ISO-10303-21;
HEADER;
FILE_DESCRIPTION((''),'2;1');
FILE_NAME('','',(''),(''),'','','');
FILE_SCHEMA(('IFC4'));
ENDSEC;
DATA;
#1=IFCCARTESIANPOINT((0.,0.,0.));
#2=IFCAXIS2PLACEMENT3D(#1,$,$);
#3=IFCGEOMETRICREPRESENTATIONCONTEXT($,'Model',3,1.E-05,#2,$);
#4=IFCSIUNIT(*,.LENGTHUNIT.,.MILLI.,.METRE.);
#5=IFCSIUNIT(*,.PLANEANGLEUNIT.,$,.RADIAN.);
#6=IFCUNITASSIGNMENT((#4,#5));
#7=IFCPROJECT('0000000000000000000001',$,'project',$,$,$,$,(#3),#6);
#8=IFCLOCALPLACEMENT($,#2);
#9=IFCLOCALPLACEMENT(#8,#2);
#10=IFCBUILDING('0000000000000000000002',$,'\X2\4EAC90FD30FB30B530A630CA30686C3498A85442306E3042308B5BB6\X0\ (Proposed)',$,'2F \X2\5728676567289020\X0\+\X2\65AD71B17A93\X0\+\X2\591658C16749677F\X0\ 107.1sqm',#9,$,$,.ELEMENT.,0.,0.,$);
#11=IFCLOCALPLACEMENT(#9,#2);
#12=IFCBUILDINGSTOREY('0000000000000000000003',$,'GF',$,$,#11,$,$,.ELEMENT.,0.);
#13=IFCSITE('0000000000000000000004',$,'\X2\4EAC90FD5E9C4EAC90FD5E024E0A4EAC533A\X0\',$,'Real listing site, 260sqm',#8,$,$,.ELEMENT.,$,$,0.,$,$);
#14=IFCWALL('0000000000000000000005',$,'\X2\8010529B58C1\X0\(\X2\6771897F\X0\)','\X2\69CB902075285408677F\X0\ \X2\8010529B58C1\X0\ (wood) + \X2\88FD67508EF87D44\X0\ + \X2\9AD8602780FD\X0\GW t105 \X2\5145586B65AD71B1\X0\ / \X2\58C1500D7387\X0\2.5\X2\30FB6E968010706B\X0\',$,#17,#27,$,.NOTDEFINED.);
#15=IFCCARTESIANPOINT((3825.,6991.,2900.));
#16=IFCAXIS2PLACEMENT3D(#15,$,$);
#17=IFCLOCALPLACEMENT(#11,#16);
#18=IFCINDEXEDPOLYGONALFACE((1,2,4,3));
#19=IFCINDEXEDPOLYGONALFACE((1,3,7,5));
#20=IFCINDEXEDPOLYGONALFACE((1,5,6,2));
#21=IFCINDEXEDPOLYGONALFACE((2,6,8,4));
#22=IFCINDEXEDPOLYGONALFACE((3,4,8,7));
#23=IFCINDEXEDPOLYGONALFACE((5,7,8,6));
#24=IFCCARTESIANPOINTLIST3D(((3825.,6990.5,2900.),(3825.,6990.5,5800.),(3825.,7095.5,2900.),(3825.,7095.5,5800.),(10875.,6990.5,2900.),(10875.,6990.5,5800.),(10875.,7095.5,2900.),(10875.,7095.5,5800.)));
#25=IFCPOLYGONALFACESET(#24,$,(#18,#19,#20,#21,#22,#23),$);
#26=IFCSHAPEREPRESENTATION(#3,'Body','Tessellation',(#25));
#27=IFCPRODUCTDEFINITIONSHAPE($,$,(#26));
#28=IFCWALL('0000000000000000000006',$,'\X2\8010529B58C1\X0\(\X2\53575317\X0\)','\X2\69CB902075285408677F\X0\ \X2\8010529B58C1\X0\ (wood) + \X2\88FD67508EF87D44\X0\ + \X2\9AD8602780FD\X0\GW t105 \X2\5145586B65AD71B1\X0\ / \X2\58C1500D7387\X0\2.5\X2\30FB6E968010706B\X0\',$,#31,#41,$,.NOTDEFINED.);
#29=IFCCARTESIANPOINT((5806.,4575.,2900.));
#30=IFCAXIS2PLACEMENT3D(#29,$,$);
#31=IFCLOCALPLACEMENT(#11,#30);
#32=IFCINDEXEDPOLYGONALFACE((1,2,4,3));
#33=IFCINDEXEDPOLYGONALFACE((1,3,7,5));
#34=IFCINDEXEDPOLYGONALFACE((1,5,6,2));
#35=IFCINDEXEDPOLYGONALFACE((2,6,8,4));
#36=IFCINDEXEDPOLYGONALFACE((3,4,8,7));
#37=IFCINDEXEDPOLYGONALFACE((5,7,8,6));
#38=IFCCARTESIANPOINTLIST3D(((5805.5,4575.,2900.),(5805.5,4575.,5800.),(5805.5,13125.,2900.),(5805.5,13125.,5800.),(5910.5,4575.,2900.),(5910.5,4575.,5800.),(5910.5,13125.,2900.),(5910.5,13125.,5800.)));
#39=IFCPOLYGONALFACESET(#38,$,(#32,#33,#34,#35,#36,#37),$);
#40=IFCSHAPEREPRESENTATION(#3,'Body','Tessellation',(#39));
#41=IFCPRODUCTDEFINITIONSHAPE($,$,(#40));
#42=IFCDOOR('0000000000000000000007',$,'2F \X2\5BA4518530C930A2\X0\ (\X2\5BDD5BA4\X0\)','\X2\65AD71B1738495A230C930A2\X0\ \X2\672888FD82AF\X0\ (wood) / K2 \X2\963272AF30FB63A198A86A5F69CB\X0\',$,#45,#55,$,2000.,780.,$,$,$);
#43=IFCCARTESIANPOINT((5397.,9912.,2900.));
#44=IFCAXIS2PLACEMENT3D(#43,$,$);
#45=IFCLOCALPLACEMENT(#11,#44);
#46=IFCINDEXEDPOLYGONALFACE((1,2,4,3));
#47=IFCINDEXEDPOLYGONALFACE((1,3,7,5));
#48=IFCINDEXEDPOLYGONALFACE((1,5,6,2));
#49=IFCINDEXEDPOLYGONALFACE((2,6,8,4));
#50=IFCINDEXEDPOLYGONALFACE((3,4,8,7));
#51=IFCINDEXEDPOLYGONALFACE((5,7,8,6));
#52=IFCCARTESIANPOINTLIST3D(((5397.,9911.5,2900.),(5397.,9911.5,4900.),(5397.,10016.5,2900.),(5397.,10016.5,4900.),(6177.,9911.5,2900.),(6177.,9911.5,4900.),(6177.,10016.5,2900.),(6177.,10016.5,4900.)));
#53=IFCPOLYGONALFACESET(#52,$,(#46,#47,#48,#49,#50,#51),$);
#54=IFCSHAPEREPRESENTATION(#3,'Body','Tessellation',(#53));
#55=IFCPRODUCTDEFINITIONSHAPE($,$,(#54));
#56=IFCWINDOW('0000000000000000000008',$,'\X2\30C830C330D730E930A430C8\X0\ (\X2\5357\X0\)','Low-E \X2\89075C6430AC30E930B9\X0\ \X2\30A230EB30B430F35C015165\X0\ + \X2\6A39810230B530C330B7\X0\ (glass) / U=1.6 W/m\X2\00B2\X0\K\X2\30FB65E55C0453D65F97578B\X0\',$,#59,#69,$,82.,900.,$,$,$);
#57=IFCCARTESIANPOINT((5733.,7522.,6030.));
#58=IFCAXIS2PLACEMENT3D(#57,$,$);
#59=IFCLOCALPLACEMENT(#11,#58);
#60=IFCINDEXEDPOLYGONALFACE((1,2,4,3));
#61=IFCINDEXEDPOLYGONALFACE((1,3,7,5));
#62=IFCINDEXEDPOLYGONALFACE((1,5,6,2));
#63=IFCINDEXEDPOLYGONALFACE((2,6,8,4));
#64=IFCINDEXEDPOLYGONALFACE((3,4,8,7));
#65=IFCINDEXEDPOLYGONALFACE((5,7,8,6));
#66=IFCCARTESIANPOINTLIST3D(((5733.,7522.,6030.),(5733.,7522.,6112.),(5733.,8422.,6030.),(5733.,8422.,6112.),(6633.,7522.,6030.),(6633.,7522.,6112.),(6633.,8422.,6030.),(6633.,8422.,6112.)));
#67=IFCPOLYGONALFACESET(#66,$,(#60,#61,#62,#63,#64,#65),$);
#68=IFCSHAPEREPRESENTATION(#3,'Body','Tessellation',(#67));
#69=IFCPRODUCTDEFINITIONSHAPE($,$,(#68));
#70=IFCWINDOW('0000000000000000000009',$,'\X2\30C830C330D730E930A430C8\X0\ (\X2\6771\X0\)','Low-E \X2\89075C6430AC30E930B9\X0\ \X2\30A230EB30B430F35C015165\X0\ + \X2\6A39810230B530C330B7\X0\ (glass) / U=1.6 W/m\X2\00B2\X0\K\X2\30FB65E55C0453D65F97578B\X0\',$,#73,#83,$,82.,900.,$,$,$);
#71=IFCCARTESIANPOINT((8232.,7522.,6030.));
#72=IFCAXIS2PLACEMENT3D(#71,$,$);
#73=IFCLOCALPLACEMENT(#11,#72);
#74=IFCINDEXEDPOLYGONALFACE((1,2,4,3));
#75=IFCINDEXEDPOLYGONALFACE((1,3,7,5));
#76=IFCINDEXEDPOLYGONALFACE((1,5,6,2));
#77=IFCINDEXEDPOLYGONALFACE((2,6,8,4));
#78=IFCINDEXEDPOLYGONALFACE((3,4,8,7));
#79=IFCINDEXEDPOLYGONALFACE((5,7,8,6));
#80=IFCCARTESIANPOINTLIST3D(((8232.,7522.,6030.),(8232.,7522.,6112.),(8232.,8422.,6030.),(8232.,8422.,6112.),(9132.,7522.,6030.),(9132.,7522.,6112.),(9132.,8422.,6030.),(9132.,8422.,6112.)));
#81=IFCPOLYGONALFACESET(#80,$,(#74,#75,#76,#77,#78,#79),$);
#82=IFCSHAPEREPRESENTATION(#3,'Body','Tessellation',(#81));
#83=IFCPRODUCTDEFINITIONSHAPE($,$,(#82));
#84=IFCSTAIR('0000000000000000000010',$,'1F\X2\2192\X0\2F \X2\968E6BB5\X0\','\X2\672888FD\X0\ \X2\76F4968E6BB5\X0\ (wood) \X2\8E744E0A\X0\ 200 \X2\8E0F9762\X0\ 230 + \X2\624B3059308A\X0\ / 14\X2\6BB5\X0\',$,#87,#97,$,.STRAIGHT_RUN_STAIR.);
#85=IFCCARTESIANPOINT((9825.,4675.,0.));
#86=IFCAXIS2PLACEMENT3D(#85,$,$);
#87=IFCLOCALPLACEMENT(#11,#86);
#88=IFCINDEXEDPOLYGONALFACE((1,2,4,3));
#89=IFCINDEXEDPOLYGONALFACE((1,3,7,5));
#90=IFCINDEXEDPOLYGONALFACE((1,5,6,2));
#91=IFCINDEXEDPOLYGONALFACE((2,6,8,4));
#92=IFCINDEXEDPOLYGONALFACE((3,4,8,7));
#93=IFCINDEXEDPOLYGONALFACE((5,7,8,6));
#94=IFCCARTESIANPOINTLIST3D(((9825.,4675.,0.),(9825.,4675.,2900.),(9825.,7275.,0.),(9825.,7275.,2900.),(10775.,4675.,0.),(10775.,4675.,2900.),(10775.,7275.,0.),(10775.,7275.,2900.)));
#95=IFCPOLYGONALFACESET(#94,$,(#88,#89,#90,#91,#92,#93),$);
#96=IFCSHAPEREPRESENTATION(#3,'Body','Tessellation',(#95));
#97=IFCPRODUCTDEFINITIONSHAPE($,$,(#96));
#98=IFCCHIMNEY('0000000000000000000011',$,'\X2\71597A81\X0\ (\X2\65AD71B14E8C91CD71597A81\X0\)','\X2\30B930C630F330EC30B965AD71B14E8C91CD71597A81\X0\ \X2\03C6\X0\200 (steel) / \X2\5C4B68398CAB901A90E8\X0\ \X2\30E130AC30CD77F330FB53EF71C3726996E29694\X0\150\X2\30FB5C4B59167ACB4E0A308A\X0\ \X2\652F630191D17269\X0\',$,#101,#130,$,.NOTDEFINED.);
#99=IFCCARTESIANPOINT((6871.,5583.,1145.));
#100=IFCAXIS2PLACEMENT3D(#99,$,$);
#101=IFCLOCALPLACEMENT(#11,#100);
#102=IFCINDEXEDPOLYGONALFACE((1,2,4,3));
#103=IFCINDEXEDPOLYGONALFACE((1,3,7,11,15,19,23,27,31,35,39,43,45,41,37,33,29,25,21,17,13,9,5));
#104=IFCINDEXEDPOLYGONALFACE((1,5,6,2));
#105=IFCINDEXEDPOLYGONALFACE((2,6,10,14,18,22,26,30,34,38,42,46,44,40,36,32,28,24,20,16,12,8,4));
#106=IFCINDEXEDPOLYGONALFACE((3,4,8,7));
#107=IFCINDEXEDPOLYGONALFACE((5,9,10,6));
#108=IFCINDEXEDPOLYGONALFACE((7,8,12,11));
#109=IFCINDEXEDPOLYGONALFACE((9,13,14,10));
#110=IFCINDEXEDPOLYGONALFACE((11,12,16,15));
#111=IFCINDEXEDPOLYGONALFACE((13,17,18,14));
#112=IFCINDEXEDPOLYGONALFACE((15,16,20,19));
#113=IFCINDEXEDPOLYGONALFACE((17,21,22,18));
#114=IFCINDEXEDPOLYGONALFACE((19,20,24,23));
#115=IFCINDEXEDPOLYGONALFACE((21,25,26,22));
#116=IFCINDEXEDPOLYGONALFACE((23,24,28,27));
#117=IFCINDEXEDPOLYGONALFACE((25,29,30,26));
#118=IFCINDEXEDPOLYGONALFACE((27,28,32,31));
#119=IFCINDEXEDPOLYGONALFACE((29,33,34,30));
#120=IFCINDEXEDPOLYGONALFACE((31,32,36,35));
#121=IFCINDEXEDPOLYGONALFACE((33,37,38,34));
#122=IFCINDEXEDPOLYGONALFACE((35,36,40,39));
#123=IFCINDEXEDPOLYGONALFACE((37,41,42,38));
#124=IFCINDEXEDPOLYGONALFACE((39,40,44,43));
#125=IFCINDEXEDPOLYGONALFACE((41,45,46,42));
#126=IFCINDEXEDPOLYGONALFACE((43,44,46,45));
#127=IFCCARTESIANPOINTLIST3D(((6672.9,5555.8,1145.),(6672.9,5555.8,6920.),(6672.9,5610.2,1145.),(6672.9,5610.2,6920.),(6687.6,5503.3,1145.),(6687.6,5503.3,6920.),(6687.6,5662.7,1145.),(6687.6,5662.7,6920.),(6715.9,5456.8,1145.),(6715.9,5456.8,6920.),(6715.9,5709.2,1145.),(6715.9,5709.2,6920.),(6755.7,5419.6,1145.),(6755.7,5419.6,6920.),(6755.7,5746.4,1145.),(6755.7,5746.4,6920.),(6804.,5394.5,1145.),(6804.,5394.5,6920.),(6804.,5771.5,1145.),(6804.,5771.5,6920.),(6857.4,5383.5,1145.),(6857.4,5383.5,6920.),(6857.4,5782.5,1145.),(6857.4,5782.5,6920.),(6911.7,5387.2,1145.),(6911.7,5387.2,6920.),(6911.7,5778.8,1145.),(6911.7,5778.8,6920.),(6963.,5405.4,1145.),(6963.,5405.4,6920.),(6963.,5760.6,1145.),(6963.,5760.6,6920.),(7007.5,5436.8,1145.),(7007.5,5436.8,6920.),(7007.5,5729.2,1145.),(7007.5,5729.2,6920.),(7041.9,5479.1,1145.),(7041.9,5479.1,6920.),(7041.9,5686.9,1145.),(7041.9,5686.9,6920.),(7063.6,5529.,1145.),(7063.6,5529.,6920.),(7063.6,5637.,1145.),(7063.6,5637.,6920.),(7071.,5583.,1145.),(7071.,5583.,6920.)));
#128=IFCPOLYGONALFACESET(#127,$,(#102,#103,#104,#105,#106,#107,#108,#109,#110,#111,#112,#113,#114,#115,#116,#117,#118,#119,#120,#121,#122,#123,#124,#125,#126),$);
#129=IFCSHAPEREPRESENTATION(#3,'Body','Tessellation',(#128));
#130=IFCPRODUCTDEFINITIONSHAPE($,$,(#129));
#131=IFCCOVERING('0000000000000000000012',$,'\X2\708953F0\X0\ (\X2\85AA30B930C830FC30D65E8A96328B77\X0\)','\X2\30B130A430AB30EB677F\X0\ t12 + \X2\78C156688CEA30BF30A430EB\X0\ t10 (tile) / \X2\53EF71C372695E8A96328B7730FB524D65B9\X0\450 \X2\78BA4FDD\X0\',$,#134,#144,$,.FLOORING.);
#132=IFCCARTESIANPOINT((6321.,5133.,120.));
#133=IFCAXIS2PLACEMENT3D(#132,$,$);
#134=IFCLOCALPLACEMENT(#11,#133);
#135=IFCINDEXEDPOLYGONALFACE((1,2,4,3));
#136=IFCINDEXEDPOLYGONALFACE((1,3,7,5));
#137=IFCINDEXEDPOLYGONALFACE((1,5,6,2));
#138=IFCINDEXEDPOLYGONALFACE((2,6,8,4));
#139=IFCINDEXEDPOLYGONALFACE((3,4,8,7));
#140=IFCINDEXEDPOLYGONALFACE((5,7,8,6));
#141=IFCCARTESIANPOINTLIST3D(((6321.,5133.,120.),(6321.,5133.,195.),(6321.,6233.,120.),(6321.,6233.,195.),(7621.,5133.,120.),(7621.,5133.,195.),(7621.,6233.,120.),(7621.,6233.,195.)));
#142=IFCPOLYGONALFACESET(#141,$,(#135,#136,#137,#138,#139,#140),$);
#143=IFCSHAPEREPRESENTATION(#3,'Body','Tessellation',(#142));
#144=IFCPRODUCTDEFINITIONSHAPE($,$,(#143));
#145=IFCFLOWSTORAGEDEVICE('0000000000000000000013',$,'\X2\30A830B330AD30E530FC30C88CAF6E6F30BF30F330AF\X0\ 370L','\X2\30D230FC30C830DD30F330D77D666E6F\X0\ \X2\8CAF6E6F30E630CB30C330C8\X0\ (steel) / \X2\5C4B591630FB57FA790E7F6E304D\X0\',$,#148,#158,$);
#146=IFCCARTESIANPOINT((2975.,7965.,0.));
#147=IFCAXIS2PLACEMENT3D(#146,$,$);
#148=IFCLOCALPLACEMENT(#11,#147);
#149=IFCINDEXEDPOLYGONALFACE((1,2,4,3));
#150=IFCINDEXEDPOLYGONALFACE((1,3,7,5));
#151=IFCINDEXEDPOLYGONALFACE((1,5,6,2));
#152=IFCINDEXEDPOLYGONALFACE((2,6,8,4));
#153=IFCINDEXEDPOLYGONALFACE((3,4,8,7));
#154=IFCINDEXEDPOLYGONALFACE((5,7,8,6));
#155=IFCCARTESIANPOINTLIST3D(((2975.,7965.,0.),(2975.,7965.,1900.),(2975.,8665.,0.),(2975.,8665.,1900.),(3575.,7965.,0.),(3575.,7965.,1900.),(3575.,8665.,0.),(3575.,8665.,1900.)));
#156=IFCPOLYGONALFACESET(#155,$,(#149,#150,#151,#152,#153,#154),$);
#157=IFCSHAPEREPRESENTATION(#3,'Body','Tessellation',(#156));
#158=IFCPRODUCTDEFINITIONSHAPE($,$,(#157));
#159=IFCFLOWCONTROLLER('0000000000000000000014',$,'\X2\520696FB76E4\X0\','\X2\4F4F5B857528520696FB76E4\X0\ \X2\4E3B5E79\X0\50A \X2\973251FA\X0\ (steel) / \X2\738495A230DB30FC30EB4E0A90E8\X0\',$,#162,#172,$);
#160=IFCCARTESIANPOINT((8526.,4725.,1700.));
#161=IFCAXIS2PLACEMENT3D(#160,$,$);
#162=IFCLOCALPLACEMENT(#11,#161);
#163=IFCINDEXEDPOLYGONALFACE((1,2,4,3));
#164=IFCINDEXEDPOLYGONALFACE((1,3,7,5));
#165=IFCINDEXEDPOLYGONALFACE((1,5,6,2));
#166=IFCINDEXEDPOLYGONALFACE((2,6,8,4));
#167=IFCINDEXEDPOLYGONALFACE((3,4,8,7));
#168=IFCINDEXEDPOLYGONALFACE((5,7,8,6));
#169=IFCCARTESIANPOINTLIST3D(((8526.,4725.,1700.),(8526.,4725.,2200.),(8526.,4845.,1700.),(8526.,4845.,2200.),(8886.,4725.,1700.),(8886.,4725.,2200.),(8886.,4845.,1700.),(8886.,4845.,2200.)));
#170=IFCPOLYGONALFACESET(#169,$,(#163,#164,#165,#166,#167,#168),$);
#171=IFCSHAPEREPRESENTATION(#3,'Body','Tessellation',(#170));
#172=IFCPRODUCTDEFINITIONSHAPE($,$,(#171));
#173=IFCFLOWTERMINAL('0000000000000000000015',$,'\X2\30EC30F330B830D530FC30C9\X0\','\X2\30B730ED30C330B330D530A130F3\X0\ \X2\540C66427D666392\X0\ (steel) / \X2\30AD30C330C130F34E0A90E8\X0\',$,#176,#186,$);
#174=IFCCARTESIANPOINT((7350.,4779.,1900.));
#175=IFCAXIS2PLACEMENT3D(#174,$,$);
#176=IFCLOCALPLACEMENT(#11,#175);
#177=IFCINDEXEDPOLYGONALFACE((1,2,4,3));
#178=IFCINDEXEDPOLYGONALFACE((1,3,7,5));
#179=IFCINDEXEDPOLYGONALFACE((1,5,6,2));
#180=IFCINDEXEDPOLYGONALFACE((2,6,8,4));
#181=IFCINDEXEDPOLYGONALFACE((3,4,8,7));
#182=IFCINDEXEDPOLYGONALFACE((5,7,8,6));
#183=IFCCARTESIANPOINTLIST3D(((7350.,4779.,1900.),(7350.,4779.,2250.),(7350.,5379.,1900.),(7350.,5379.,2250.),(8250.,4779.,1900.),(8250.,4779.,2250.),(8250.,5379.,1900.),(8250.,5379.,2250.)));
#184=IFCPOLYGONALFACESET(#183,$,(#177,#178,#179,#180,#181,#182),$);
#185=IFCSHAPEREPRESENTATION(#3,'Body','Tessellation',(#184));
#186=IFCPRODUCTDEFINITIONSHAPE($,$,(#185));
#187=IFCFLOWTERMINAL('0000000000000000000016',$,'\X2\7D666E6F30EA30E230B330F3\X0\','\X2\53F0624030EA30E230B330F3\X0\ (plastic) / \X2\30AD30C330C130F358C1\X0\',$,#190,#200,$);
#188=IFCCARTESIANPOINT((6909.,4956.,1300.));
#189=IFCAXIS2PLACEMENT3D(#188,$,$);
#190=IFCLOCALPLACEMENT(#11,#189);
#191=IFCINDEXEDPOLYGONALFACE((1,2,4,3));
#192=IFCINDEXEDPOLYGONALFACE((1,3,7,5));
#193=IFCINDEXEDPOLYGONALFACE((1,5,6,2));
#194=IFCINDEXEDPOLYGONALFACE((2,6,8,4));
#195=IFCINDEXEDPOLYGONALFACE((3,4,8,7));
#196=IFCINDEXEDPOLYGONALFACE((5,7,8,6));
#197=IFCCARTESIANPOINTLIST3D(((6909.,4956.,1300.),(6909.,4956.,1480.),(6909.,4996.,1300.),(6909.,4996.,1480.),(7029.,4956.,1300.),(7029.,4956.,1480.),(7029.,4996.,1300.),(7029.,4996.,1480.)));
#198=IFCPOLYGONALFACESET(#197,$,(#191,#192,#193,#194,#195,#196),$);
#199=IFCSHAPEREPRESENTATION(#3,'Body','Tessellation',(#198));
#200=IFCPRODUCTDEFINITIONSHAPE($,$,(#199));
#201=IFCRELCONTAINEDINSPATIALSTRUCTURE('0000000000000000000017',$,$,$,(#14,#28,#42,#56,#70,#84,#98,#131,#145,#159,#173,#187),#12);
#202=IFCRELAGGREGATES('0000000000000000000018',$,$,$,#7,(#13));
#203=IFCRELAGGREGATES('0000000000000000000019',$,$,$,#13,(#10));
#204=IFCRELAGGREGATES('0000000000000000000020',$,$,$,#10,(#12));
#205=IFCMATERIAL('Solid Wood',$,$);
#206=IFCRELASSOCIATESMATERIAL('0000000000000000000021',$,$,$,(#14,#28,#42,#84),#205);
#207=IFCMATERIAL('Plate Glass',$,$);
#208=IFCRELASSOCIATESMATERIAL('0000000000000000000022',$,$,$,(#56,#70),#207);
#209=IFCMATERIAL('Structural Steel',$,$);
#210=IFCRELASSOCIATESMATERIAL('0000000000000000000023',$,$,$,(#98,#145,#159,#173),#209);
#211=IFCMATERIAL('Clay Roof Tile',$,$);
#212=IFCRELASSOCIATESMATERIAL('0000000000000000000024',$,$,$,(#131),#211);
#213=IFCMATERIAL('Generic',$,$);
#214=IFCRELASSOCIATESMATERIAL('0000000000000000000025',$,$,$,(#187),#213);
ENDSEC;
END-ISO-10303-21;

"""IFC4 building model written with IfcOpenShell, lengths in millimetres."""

from ifc_helpers import new_model, si_unit, frame, frame_2d, origin, origin_2d, place, context, project, spatial, rectangle, circle, extrude, material, element, fill, save


model = new_model("IFC4")

# Units and contexts
model_context = context("Model", 3, precision=1e-05, world=origin())
ifc_project = project(units=[si_unit("LENGTHUNIT", "METRE", prefix="MILLI"), si_unit("PLANEANGLEUNIT", "RADIAN")], contexts=[model_context])

# Site, building, storey
site_placement = place(None, origin())
site = spatial("IfcSite", under=ifc_project, at=site_placement, Name="京都府京都市上京区", ObjectType="Real listing site, 260sqm", CompositionType="ELEMENT", RefElevation=0.0)
building_placement = place(site_placement, origin())
building = spatial("IfcBuilding", under=site, at=building_placement, Name="京都・サウナと水風呂のある家 (Proposed)", ObjectType="2F 在来木造+断熱窓+外壁杉板 107.1sqm", CompositionType="ELEMENT", ElevationOfRefHeight=0.0, ElevationOfTerrain=0.0)
storey_placement = place(building_placement, origin())
storey = spatial("IfcBuildingStorey", under=building, at=storey_placement, Name="GF", CompositionType="ELEMENT", Elevation=0.0)

# Shared definitions
ifc_material_1 = material(Name="Solid Wood")

# Wall
wall_1_placement = place(storey_placement, frame((3825.0, 6991.0, 2900.0)))
element("IfcWall", 1, at=wall_1_placement, inside=storey, material=ifc_material_1, Name="耐力壁(東西)", Description="構造用合板 耐力壁 (wood) + 製材軸組 + 高性能GW t105 充填断熱 / 壁倍率2.5・準耐火", PredefinedType="NOTDEFINED", context=model_context, shape_type="SweptSolid", body=[
    extrude(rectangle(XDim=7050.0, YDim=105.0, at=frame_2d((3525.0, 52.0))), frame((3825.0, 6991.0, 2900.0)), (0.0, 0.0, 1.0), 2900.0),
])

# Wall, opening, door
wall_2_placement = place(storey_placement, frame((5806.0, 4575.0, 2900.0)))
wall_2 = element("IfcWall", 2, at=wall_2_placement, inside=storey, material=ifc_material_1, Name="耐力壁(南北)", Description="構造用合板 耐力壁 (wood) + 製材軸組 + 高性能GW t105 充填断熱 / 壁倍率2.5・準耐火", PredefinedType="NOTDEFINED", context=model_context, shape_type="SweptSolid", body=[
    extrude(rectangle(XDim=105.0, YDim=8550.0, at=frame_2d((52.0, 4275.0))), frame((5806.0, 4575.0, 2900.0)), (0.0, 0.0, 1.0), 2900.0),
])
opening_placement = place(storey_placement, frame((5397.0, 9912.0, 2900.0)))
opening = element("IfcOpeningElement", 3, at=opening_placement, cuts=wall_2, PredefinedType="NOTDEFINED", context=model_context, shape_type="SweptSolid", body=[
    extrude(rectangle(XDim=780.0, YDim=105.0, at=frame_2d((390.0, 52.0))), frame((5397.0, 9912.0, 2900.0)), (0.0, 0.0, 1.0), 2000.0),
])
door_placement = place(storey_placement, frame((5397.0, 9912.0, 2900.0)))
door = element("IfcDoor", 4, at=door_placement, inside=storey, material=ifc_material_1, Name="2F 室内ドア (寝室)", Description="断熱玄関ドア 木製芯 (wood) / K2 防犯・採風機構", OverallHeight=2000.0, OverallWidth=780.0, context=model_context, shape_type="SweptSolid", body=[
    extrude(rectangle(XDim=780.0, YDim=105.0, at=frame_2d((390.0, 52.0))), frame((5397.0, 9912.0, 2900.0)), (0.0, 0.0, 1.0), 2000.0),
])
fill(opening, door)

# Windows
ifc_material_2 = material(Name="Plate Glass")
window_1_placement = place(storey_placement, frame((5733.0, 7522.0, 6030.0)))
element("IfcWindow", 5, at=window_1_placement, inside=storey, material=ifc_material_2, Name="トップライト (南)", Description="Low-E 複層ガラス アルゴン封入 + 樹脂サッシ (glass) / U=1.6 W/m²K・日射取得型", OverallHeight=82.0, OverallWidth=900.0, context=model_context, shape_type="SweptSolid", body=[
    extrude(rectangle(XDim=900.0, YDim=900.0, at=frame_2d((450.0, 450.0))), frame((5733.0, 7522.0, 6030.0)), (0.0, 0.0, 1.0), 82.0),
])
window_2_placement = place(storey_placement, frame((8232.0, 7522.0, 6030.0)))
element("IfcWindow", 6, at=window_2_placement, inside=storey, material=ifc_material_2, Name="トップライト (東)", Description="Low-E 複層ガラス アルゴン封入 + 樹脂サッシ (glass) / U=1.6 W/m²K・日射取得型", OverallHeight=82.0, OverallWidth=900.0, context=model_context, shape_type="SweptSolid", body=[
    extrude(rectangle(XDim=900.0, YDim=900.0, at=frame_2d((450.0, 450.0))), frame((8232.0, 7522.0, 6030.0)), (0.0, 0.0, 1.0), 82.0),
])

# Stair
stair_placement = place(storey_placement, frame((9825.0, 4675.0, 0.0)))
element("IfcStair", 7, at=stair_placement, inside=storey, material=ifc_material_1, Name="1F→2F 階段", Description="木製 直階段 (wood) 蹴上 200 踏面 230 + 手すり / 14段", PredefinedType="STRAIGHT_RUN_STAIR", context=model_context, shape_type="SweptSolid", body=[
    extrude(rectangle(XDim=950.0, YDim=2600.0, at=frame_2d((475.0, 1300.0))), frame((9825.0, 4675.0, 0.0)), (0.0, 0.0, 1.0), 2900.0),
])

# Chimney
ifc_material_3 = material(Name="Structural Steel")
chimney_placement = place(storey_placement, frame((6871.0, 5583.0, 1145.0)))
element("IfcChimney", 8, at=chimney_placement, inside=storey, material=ifc_material_3, Name="煙突 (断熱二重煙突)", Description="ステンレス断熱二重煙突 φ200 (steel) / 屋根貫通部 メガネ石・可燃物離隔150・屋外立上り 支持金物", PredefinedType="NOTDEFINED", context=model_context, shape_type="SweptSolid", body=[
    extrude(circle(Radius=200.0, at=origin_2d()), frame((6871.0, 5583.0, 1145.0)), (0.0, 0.0, 1.0), 5775.0),
])

# Covering
ifc_material_4 = material(Name="Clay Roof Tile")
covering_placement = place(storey_placement, frame((6321.0, 5133.0, 120.0)))
element("IfcCovering", 9, at=covering_placement, inside=storey, material=ifc_material_4, Name="炉台 (薪ストーブ床防護)", Description="ケイカル板 t12 + 磁器質タイル t10 (tile) / 可燃物床防護・前方450 確保", PredefinedType="FLOORING", context=model_context, shape_type="SweptSolid", body=[
    extrude(rectangle(XDim=1300.0, YDim=1100.0, at=frame_2d((650.0, 550.0))), frame((6321.0, 5133.0, 120.0)), (0.0, 0.0, 1.0), 75.0),
])

# Flow storage device
flow_storage_device_placement = place(storey_placement, frame((2975.0, 7965.0, 0.0)))
element("IfcFlowStorageDevice", 10, at=flow_storage_device_placement, inside=storey, material=ifc_material_3, Name="エコキュート貯湯タンク 370L", Description="ヒートポンプ給湯 貯湯ユニット (steel) / 屋外・基礎置き", context=model_context, shape_type="SweptSolid", body=[
    extrude(rectangle(XDim=600.0, YDim=700.0, at=frame_2d((300.0, 350.0))), frame((2975.0, 7965.0, 0.0)), (0.0, 0.0, 1.0), 1900.0),
])

# Flow controller
flow_controller_placement = place(storey_placement, frame((8526.0, 4725.0, 1700.0)))
element("IfcFlowController", 11, at=flow_controller_placement, inside=storey, material=ifc_material_3, Name="分電盤", Description="住宅用分電盤 主幹50A 露出 (steel) / 玄関ホール上部", context=model_context, shape_type="SweptSolid", body=[
    extrude(rectangle(XDim=360.0, YDim=120.0, at=frame_2d((180.0, 60.0))), frame((8526.0, 4725.0, 1700.0)), (0.0, 0.0, 1.0), 500.0),
])

# Flow terminals
flow_terminal_1_placement = place(storey_placement, frame((7350.0, 4779.0, 1900.0)))
element("IfcFlowTerminal", 12, at=flow_terminal_1_placement, inside=storey, material=ifc_material_3, Name="レンジフード", Description="シロッコファン 同時給排 (steel) / キッチン上部", context=model_context, shape_type="SweptSolid", body=[
    extrude(rectangle(XDim=900.0, YDim=600.0, at=frame_2d((450.0, 300.0))), frame((7350.0, 4779.0, 1900.0)), (0.0, 0.0, 1.0), 350.0),
])
ifc_material_5 = material(Name="Generic")
flow_terminal_2_placement = place(storey_placement, frame((6909.0, 4956.0, 1300.0)))
element("IfcFlowTerminal", 13, at=flow_terminal_2_placement, inside=storey, material=ifc_material_5, Name="給湯リモコン", Description="台所リモコン (plastic) / キッチン壁", context=model_context, shape_type="SweptSolid", body=[
    extrude(rectangle(XDim=120.0, YDim=40.0, at=frame_2d((60.0, 20.0))), frame((6909.0, 4956.0, 1300.0)), (0.0, 0.0, 1.0), 180.0),
])

save(model, "model.ifc")
